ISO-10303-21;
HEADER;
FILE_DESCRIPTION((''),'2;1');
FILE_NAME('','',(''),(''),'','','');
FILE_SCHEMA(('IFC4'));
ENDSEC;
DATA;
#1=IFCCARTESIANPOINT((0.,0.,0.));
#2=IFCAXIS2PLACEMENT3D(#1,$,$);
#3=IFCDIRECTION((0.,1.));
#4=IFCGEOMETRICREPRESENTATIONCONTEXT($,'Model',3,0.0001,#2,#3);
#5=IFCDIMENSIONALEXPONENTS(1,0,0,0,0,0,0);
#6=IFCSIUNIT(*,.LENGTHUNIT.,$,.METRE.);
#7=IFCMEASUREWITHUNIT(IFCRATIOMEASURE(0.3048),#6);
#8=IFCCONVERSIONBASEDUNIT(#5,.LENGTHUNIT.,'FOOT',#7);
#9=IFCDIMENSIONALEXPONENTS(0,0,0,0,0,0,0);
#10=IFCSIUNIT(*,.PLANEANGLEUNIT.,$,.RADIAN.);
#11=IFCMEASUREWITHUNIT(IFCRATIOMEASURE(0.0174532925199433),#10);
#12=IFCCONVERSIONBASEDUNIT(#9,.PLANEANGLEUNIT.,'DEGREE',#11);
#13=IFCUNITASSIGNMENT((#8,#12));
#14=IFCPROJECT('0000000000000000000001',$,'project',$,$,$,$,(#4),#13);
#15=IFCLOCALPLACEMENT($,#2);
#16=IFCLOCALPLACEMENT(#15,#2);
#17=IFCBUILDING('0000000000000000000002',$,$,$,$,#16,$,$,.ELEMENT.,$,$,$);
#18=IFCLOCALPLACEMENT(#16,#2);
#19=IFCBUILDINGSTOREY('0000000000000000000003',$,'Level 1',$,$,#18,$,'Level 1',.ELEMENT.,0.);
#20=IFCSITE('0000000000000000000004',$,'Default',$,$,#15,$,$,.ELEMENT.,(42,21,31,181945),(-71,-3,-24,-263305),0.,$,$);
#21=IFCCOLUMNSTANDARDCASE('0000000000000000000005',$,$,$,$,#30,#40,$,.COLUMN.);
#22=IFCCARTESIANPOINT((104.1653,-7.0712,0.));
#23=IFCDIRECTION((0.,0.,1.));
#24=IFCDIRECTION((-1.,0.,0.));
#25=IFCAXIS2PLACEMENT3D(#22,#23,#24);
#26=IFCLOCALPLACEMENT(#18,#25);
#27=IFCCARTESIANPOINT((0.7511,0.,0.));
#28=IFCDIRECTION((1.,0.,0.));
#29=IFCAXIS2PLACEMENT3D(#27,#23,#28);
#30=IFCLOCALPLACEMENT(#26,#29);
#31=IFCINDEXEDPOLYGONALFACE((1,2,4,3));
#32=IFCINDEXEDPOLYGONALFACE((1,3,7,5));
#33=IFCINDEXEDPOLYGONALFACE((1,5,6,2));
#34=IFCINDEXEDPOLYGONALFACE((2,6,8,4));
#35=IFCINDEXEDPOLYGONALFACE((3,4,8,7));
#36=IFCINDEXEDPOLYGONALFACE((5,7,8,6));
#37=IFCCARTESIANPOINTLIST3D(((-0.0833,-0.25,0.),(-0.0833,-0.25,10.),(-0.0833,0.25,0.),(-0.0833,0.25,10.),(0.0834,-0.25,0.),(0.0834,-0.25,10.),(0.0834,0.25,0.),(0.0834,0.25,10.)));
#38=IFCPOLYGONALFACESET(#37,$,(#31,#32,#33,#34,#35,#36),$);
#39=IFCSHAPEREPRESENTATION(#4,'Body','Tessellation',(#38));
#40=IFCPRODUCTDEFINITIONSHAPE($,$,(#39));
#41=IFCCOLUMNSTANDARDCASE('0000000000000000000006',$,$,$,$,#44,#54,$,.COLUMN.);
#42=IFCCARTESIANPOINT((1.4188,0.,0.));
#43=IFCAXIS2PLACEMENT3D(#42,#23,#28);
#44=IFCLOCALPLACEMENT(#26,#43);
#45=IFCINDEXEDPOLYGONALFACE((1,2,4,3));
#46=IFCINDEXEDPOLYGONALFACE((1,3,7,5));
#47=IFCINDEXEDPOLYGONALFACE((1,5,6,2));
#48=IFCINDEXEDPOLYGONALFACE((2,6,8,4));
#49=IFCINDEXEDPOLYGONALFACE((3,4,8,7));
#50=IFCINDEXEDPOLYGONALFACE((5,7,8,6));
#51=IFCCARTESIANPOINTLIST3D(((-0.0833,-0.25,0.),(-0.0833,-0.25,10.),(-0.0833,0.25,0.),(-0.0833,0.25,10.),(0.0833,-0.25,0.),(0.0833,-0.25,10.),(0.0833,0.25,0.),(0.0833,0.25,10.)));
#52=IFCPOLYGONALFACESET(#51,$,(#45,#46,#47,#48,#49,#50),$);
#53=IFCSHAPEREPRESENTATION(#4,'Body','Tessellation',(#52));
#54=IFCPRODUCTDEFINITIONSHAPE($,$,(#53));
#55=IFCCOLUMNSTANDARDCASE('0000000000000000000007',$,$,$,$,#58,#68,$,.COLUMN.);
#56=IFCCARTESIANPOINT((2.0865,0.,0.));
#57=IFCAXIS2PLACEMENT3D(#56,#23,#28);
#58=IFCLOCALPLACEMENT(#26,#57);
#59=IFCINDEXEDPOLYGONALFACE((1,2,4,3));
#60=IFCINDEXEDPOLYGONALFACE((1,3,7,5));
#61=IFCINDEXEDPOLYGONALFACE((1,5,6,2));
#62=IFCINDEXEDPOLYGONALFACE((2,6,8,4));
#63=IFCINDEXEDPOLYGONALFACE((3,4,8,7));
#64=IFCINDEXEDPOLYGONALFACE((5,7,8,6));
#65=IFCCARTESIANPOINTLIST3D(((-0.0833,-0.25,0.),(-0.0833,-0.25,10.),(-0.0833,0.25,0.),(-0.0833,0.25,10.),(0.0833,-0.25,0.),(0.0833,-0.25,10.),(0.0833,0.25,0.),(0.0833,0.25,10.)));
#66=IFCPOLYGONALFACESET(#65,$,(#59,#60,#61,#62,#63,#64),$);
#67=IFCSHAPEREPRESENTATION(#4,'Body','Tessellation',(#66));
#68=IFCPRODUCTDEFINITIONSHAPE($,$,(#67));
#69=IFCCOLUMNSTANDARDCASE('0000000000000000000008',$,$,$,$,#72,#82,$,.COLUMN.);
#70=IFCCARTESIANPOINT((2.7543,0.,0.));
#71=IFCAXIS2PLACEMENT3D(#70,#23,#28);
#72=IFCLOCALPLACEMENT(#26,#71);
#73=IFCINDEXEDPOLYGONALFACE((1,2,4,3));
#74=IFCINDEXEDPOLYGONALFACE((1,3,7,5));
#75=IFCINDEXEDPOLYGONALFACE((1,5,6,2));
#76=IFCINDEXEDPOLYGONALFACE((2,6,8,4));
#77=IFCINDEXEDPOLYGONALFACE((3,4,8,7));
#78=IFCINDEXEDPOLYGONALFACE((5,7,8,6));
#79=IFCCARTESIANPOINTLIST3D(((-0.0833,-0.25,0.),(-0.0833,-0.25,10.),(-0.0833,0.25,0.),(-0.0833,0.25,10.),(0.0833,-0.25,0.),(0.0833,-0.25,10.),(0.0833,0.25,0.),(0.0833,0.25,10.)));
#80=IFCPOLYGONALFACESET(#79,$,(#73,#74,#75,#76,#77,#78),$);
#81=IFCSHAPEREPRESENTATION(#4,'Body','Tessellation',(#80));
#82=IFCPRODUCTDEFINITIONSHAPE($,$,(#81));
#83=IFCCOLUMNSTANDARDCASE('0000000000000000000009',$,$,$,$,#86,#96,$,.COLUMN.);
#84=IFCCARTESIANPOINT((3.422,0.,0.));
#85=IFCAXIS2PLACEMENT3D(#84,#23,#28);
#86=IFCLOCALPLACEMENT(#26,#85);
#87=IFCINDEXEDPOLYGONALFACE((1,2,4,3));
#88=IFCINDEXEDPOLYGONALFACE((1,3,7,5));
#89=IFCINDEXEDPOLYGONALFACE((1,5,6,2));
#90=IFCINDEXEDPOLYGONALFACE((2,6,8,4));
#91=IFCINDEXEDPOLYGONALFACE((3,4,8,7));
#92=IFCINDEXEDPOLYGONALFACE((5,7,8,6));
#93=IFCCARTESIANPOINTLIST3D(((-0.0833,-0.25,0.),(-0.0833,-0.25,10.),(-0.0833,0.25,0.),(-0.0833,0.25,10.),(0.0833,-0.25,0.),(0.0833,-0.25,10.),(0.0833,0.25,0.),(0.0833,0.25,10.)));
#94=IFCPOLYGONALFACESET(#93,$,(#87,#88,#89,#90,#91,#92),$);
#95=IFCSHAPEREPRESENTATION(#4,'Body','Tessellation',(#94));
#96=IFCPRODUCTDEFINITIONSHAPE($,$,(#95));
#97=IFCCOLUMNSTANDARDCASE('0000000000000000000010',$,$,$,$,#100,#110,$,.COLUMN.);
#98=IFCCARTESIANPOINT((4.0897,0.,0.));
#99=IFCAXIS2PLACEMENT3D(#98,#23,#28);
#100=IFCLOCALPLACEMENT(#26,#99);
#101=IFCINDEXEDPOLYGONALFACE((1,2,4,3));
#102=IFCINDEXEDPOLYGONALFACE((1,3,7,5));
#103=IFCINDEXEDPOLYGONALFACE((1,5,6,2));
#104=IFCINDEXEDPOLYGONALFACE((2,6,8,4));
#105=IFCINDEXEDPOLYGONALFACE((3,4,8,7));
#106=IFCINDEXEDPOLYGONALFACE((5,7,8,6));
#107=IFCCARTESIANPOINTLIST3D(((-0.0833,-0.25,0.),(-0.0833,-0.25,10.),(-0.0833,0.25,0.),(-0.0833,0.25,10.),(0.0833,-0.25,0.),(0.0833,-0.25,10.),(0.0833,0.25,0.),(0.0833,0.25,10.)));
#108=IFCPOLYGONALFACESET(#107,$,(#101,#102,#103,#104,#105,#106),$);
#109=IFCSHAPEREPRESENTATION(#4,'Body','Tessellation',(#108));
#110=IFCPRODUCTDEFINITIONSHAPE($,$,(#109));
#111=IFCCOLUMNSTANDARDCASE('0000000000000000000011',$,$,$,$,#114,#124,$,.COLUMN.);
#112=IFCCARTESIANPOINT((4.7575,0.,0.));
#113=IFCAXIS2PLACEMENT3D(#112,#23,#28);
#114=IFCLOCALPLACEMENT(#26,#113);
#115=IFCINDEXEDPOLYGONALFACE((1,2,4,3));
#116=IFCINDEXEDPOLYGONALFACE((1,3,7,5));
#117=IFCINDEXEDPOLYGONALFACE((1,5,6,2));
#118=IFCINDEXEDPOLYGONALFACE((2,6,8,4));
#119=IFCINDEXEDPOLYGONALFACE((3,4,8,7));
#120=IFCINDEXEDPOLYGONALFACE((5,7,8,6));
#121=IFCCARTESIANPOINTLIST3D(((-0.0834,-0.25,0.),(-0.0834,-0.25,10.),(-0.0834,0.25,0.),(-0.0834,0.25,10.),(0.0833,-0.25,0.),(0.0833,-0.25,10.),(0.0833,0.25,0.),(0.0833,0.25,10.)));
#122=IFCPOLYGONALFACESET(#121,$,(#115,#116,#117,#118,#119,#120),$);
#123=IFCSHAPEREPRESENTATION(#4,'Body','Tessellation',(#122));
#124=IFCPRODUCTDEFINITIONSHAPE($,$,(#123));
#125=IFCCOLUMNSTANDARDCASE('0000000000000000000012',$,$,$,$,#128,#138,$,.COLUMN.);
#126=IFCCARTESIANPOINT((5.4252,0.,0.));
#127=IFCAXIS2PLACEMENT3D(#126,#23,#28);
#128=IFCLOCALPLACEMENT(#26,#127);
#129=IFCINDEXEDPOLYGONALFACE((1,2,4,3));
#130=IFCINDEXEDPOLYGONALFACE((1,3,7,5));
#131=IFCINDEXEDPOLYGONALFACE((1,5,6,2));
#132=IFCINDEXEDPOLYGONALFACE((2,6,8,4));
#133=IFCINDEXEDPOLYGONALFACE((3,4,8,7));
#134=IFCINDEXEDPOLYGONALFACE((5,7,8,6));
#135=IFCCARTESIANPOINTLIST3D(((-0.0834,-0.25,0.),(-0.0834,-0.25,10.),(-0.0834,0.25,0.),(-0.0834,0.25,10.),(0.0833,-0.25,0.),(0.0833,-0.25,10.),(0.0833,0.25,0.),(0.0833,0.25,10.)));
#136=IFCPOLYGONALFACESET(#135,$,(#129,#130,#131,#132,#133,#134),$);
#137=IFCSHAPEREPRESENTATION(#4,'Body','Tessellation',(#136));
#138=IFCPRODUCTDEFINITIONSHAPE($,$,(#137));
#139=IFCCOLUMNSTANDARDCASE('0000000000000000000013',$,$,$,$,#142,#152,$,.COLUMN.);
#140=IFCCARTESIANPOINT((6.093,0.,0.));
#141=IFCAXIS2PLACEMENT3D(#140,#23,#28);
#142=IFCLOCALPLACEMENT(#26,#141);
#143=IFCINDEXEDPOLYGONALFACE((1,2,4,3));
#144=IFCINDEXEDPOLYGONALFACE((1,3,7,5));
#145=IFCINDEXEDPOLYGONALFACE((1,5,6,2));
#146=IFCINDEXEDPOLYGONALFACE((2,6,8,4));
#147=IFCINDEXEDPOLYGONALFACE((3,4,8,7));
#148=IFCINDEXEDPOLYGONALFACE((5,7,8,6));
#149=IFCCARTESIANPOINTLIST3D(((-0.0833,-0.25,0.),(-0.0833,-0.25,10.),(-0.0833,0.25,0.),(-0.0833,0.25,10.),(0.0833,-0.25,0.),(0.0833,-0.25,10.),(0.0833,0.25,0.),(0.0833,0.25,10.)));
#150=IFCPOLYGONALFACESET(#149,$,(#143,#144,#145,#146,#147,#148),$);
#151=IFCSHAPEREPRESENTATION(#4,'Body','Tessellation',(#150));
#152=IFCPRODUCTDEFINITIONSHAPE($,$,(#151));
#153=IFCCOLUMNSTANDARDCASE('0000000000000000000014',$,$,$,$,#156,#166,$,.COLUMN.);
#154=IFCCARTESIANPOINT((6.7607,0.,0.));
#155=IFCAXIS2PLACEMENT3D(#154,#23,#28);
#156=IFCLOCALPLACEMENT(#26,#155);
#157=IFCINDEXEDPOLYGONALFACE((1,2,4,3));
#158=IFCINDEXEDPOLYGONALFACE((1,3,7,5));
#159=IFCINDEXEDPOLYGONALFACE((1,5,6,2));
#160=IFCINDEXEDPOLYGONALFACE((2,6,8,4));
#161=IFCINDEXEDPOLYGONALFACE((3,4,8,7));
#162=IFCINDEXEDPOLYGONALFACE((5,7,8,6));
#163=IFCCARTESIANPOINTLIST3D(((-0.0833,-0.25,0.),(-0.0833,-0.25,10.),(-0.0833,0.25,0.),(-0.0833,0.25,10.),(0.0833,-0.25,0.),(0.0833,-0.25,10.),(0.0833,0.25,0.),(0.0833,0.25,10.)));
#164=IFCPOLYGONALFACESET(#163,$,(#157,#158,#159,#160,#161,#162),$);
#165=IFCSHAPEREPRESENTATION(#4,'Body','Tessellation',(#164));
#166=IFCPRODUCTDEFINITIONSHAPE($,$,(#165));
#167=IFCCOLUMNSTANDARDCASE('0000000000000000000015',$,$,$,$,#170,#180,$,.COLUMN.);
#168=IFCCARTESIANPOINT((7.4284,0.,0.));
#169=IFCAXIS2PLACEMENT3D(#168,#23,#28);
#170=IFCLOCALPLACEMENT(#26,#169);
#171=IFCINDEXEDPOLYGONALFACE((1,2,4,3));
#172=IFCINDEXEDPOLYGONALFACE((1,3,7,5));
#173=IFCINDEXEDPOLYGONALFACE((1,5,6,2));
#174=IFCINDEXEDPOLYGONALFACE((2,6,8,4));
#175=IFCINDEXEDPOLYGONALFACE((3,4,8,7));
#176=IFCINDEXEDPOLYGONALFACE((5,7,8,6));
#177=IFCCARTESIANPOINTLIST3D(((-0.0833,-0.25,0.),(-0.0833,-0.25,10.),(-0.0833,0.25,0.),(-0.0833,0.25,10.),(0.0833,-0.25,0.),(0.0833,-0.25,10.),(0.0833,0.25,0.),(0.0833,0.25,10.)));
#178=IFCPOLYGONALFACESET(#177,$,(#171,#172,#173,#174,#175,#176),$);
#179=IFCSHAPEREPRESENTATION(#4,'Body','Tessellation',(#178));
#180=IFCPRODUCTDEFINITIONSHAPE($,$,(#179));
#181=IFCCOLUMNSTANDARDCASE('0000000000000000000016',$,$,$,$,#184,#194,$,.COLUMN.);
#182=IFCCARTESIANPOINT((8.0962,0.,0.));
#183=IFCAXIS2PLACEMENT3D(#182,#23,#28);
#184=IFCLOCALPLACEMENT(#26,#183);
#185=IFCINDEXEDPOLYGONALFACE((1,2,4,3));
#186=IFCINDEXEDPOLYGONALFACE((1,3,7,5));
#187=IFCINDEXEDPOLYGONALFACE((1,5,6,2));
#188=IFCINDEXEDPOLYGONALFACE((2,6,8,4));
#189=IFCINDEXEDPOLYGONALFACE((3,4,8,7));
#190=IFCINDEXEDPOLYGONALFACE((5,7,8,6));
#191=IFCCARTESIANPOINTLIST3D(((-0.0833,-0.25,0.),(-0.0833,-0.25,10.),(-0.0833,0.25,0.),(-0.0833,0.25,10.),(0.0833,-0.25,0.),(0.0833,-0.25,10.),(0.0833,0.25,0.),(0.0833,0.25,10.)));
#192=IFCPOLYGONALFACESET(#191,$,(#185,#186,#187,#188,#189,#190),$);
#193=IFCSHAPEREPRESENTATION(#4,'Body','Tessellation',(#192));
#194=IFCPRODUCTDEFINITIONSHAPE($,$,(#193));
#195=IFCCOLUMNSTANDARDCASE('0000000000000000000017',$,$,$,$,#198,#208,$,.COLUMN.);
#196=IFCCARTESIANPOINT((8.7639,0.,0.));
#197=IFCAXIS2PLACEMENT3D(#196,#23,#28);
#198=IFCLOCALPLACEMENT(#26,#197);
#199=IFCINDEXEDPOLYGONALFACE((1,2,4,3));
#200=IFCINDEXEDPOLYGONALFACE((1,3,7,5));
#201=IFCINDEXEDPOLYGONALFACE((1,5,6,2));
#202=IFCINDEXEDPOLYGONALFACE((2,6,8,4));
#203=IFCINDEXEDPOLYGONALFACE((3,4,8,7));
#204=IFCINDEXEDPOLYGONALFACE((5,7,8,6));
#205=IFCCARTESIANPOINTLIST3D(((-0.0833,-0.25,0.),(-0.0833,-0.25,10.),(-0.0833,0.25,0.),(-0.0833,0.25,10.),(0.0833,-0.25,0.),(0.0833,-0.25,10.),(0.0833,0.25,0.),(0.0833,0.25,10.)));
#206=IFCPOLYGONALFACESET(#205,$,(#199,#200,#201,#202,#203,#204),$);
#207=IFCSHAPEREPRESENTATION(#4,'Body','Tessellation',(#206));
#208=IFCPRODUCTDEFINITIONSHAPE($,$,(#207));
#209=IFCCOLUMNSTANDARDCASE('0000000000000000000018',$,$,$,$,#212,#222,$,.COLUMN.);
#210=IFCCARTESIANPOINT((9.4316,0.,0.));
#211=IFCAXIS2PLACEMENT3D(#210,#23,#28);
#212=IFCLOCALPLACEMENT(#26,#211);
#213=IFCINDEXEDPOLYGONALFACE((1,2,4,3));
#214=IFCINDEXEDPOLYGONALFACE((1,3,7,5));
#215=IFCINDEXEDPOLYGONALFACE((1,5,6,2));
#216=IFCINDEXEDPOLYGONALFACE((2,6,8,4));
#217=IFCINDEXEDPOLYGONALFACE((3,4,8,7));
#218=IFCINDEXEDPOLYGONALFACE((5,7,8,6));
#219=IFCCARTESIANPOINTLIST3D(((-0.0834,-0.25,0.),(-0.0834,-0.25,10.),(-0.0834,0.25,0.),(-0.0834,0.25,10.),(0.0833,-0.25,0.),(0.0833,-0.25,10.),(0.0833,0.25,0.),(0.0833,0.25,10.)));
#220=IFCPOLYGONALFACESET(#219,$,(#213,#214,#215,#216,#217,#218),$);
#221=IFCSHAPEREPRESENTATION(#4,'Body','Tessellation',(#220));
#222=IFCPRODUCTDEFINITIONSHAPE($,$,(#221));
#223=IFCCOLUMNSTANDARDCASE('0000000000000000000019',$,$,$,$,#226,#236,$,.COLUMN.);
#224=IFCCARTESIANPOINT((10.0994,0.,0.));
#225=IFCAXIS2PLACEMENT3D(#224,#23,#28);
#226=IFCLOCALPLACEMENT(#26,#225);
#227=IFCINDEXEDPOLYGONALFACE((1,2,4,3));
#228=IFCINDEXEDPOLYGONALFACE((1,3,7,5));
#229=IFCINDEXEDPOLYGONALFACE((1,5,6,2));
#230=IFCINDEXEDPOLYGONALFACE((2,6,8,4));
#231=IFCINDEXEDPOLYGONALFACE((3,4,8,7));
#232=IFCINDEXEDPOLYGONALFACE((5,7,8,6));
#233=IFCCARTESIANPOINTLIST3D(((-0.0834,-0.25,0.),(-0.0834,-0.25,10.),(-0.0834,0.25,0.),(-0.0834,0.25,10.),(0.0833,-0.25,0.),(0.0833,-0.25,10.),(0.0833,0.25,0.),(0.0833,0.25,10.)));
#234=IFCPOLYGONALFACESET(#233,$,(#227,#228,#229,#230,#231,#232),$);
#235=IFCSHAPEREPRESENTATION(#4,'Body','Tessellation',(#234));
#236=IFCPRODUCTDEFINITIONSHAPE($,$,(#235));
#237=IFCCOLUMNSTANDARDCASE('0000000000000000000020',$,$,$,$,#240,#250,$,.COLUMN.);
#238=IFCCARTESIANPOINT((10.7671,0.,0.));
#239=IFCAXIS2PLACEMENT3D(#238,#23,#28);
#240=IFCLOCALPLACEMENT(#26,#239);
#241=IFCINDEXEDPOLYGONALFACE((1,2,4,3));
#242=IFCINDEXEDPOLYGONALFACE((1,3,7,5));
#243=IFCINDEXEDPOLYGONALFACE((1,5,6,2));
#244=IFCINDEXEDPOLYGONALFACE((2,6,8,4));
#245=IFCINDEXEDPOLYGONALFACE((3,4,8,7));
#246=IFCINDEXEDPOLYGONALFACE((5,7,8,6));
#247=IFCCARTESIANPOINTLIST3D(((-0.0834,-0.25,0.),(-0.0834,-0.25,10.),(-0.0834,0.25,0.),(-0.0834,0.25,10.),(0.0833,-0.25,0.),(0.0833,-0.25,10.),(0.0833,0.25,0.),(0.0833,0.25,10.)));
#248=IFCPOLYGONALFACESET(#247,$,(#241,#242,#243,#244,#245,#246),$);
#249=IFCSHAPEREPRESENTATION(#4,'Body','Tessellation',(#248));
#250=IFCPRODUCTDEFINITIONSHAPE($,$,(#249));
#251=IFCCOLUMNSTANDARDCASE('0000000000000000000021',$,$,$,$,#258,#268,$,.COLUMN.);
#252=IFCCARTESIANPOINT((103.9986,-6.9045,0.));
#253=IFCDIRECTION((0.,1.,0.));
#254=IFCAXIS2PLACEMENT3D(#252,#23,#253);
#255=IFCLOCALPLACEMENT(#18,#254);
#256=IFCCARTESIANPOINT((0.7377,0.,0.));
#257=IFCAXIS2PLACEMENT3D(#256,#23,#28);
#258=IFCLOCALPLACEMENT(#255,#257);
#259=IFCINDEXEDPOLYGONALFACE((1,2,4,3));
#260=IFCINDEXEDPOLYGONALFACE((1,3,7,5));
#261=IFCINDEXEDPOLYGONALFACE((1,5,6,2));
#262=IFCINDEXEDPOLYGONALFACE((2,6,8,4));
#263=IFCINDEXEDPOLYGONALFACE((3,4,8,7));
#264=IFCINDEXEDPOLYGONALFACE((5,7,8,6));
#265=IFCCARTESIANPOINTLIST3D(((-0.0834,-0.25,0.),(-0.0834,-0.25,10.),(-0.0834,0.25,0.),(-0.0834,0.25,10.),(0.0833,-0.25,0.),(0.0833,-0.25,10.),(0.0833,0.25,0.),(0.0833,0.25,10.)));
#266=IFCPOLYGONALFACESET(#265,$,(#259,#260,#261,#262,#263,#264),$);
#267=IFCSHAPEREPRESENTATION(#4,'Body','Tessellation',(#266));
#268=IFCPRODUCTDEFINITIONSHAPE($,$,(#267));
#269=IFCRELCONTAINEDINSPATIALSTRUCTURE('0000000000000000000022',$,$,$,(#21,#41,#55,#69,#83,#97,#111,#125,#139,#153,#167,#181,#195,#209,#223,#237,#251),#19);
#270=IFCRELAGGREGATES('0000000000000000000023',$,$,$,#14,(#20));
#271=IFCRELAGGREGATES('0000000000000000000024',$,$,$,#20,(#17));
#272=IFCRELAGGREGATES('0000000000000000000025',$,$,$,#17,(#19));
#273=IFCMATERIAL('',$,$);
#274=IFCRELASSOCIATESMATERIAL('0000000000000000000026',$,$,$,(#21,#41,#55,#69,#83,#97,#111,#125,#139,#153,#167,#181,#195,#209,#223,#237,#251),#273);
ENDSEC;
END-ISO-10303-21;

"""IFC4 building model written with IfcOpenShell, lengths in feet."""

from ifc_helpers import new_model, entity, si_unit, converted_unit, direction, frame, origin, place, context, project, spatial, rectangle, extrude, material, element, save


model = new_model("IFC4")

# Units and contexts
model_context = context("Model", 3, precision=0.0001, world=origin(), true_north=direction((0.0, 1.0)))
ifc_project = project(units=[converted_unit("LENGTHUNIT", "FOOT", entity("IfcRatioMeasure", 0.3048), si_unit("LENGTHUNIT", "METRE"), dimensions=[1, 0, 0, 0, 0, 0, 0]), converted_unit("PLANEANGLEUNIT", "DEGREE", entity("IfcRatioMeasure", 0.0174532925199433), si_unit("PLANEANGLEUNIT", "RADIAN"), dimensions=[0, 0, 0, 0, 0, 0, 0])], contexts=[model_context])

# Site, building, storey
site_placement = place(None, origin())
site = spatial("IfcSite", under=ifc_project, at=site_placement, Name="Default", CompositionType="ELEMENT", RefLatitude=(42, 21, 31, 181945), RefLongitude=(-71, -3, -24, -263305), RefElevation=0.0)
building_placement = place(site_placement, origin())
building = spatial("IfcBuilding", under=site, at=building_placement, CompositionType="ELEMENT")
storey_placement = place(building_placement, origin())
storey = spatial("IfcBuildingStorey", under=building, at=storey_placement, Name="Level 1", LongName="Level 1", CompositionType="ELEMENT", Elevation=0.0)

# Columns
ifc_material = material(Name="")
placement_1 = place(storey_placement, frame((104.1653, -7.0712, 0.0), z_axis=(0.0, 0.0, 1.0), x_axis=(-1.0, 0.0, 0.0)))
for number, where, z_axis, x_axis in (
    (1, (0.7511, 0.0, 0.0), (0.0, 0.0, 1.0), (1.0, 0.0, 0.0)),
    (2, (1.4188, 0.0, 0.0), (0.0, 0.0, 1.0), (1.0, 0.0, 0.0)),
    (3, (2.0865, 0.0, 0.0), (0.0, 0.0, 1.0), (1.0, 0.0, 0.0)),
    (4, (2.7543, 0.0, 0.0), (0.0, 0.0, 1.0), (1.0, 0.0, 0.0)),
    (5, (3.422, 0.0, 0.0), (0.0, 0.0, 1.0), (1.0, 0.0, 0.0)),
    (6, (4.0897, 0.0, 0.0), (0.0, 0.0, 1.0), (1.0, 0.0, 0.0)),
    (7, (4.7575, 0.0, 0.0), (0.0, 0.0, 1.0), (1.0, 0.0, 0.0)),
    (8, (5.4252, 0.0, 0.0), (0.0, 0.0, 1.0), (1.0, 0.0, 0.0)),
    (9, (6.093, 0.0, 0.0), (0.0, 0.0, 1.0), (1.0, 0.0, 0.0)),
    (10, (6.7607, 0.0, 0.0), (0.0, 0.0, 1.0), (1.0, 0.0, 0.0)),
    (11, (7.4284, 0.0, 0.0), (0.0, 0.0, 1.0), (1.0, 0.0, 0.0)),
    (12, (8.0962, 0.0, 0.0), (0.0, 0.0, 1.0), (1.0, 0.0, 0.0)),
    (13, (8.7639, 0.0, 0.0), (0.0, 0.0, 1.0), (1.0, 0.0, 0.0)),
    (14, (9.4316, 0.0, 0.0), (0.0, 0.0, 1.0), (1.0, 0.0, 0.0)),
    (15, (10.0994, 0.0, 0.0), (0.0, 0.0, 1.0), (1.0, 0.0, 0.0)),
    (16, (10.7671, 0.0, 0.0), (0.0, 0.0, 1.0), (1.0, 0.0, 0.0)),
):
    element("IfcColumnStandardCase", number, at=place(placement_1, frame(where, z_axis=z_axis, x_axis=x_axis)), inside=storey, material=ifc_material, PredefinedType="COLUMN", context=model_context, shape_type="SweptSolid", body=[
        extrude(rectangle(XDim=0.1667, YDim=0.5), origin(), (0.0, 0.0, 1.0), 10.0),
    ])
placement_2 = place(storey_placement, frame((103.9986, -6.9045, 0.0), z_axis=(0.0, 0.0, 1.0), x_axis=(0.0, 1.0, 0.0)))
for number, where, z_axis, x_axis in (
    (17, (0.7377, 0.0, 0.0), (0.0, 0.0, 1.0), (1.0, 0.0, 0.0)),
):
    element("IfcColumnStandardCase", number, at=place(placement_2, frame(where, z_axis=z_axis, x_axis=x_axis)), inside=storey, material=ifc_material, PredefinedType="COLUMN", context=model_context, shape_type="SweptSolid", body=[
        extrude(rectangle(XDim=0.1667, YDim=0.5), origin(), (0.0, 0.0, 1.0), 10.0),
    ])

save(model, "model.ifc")
